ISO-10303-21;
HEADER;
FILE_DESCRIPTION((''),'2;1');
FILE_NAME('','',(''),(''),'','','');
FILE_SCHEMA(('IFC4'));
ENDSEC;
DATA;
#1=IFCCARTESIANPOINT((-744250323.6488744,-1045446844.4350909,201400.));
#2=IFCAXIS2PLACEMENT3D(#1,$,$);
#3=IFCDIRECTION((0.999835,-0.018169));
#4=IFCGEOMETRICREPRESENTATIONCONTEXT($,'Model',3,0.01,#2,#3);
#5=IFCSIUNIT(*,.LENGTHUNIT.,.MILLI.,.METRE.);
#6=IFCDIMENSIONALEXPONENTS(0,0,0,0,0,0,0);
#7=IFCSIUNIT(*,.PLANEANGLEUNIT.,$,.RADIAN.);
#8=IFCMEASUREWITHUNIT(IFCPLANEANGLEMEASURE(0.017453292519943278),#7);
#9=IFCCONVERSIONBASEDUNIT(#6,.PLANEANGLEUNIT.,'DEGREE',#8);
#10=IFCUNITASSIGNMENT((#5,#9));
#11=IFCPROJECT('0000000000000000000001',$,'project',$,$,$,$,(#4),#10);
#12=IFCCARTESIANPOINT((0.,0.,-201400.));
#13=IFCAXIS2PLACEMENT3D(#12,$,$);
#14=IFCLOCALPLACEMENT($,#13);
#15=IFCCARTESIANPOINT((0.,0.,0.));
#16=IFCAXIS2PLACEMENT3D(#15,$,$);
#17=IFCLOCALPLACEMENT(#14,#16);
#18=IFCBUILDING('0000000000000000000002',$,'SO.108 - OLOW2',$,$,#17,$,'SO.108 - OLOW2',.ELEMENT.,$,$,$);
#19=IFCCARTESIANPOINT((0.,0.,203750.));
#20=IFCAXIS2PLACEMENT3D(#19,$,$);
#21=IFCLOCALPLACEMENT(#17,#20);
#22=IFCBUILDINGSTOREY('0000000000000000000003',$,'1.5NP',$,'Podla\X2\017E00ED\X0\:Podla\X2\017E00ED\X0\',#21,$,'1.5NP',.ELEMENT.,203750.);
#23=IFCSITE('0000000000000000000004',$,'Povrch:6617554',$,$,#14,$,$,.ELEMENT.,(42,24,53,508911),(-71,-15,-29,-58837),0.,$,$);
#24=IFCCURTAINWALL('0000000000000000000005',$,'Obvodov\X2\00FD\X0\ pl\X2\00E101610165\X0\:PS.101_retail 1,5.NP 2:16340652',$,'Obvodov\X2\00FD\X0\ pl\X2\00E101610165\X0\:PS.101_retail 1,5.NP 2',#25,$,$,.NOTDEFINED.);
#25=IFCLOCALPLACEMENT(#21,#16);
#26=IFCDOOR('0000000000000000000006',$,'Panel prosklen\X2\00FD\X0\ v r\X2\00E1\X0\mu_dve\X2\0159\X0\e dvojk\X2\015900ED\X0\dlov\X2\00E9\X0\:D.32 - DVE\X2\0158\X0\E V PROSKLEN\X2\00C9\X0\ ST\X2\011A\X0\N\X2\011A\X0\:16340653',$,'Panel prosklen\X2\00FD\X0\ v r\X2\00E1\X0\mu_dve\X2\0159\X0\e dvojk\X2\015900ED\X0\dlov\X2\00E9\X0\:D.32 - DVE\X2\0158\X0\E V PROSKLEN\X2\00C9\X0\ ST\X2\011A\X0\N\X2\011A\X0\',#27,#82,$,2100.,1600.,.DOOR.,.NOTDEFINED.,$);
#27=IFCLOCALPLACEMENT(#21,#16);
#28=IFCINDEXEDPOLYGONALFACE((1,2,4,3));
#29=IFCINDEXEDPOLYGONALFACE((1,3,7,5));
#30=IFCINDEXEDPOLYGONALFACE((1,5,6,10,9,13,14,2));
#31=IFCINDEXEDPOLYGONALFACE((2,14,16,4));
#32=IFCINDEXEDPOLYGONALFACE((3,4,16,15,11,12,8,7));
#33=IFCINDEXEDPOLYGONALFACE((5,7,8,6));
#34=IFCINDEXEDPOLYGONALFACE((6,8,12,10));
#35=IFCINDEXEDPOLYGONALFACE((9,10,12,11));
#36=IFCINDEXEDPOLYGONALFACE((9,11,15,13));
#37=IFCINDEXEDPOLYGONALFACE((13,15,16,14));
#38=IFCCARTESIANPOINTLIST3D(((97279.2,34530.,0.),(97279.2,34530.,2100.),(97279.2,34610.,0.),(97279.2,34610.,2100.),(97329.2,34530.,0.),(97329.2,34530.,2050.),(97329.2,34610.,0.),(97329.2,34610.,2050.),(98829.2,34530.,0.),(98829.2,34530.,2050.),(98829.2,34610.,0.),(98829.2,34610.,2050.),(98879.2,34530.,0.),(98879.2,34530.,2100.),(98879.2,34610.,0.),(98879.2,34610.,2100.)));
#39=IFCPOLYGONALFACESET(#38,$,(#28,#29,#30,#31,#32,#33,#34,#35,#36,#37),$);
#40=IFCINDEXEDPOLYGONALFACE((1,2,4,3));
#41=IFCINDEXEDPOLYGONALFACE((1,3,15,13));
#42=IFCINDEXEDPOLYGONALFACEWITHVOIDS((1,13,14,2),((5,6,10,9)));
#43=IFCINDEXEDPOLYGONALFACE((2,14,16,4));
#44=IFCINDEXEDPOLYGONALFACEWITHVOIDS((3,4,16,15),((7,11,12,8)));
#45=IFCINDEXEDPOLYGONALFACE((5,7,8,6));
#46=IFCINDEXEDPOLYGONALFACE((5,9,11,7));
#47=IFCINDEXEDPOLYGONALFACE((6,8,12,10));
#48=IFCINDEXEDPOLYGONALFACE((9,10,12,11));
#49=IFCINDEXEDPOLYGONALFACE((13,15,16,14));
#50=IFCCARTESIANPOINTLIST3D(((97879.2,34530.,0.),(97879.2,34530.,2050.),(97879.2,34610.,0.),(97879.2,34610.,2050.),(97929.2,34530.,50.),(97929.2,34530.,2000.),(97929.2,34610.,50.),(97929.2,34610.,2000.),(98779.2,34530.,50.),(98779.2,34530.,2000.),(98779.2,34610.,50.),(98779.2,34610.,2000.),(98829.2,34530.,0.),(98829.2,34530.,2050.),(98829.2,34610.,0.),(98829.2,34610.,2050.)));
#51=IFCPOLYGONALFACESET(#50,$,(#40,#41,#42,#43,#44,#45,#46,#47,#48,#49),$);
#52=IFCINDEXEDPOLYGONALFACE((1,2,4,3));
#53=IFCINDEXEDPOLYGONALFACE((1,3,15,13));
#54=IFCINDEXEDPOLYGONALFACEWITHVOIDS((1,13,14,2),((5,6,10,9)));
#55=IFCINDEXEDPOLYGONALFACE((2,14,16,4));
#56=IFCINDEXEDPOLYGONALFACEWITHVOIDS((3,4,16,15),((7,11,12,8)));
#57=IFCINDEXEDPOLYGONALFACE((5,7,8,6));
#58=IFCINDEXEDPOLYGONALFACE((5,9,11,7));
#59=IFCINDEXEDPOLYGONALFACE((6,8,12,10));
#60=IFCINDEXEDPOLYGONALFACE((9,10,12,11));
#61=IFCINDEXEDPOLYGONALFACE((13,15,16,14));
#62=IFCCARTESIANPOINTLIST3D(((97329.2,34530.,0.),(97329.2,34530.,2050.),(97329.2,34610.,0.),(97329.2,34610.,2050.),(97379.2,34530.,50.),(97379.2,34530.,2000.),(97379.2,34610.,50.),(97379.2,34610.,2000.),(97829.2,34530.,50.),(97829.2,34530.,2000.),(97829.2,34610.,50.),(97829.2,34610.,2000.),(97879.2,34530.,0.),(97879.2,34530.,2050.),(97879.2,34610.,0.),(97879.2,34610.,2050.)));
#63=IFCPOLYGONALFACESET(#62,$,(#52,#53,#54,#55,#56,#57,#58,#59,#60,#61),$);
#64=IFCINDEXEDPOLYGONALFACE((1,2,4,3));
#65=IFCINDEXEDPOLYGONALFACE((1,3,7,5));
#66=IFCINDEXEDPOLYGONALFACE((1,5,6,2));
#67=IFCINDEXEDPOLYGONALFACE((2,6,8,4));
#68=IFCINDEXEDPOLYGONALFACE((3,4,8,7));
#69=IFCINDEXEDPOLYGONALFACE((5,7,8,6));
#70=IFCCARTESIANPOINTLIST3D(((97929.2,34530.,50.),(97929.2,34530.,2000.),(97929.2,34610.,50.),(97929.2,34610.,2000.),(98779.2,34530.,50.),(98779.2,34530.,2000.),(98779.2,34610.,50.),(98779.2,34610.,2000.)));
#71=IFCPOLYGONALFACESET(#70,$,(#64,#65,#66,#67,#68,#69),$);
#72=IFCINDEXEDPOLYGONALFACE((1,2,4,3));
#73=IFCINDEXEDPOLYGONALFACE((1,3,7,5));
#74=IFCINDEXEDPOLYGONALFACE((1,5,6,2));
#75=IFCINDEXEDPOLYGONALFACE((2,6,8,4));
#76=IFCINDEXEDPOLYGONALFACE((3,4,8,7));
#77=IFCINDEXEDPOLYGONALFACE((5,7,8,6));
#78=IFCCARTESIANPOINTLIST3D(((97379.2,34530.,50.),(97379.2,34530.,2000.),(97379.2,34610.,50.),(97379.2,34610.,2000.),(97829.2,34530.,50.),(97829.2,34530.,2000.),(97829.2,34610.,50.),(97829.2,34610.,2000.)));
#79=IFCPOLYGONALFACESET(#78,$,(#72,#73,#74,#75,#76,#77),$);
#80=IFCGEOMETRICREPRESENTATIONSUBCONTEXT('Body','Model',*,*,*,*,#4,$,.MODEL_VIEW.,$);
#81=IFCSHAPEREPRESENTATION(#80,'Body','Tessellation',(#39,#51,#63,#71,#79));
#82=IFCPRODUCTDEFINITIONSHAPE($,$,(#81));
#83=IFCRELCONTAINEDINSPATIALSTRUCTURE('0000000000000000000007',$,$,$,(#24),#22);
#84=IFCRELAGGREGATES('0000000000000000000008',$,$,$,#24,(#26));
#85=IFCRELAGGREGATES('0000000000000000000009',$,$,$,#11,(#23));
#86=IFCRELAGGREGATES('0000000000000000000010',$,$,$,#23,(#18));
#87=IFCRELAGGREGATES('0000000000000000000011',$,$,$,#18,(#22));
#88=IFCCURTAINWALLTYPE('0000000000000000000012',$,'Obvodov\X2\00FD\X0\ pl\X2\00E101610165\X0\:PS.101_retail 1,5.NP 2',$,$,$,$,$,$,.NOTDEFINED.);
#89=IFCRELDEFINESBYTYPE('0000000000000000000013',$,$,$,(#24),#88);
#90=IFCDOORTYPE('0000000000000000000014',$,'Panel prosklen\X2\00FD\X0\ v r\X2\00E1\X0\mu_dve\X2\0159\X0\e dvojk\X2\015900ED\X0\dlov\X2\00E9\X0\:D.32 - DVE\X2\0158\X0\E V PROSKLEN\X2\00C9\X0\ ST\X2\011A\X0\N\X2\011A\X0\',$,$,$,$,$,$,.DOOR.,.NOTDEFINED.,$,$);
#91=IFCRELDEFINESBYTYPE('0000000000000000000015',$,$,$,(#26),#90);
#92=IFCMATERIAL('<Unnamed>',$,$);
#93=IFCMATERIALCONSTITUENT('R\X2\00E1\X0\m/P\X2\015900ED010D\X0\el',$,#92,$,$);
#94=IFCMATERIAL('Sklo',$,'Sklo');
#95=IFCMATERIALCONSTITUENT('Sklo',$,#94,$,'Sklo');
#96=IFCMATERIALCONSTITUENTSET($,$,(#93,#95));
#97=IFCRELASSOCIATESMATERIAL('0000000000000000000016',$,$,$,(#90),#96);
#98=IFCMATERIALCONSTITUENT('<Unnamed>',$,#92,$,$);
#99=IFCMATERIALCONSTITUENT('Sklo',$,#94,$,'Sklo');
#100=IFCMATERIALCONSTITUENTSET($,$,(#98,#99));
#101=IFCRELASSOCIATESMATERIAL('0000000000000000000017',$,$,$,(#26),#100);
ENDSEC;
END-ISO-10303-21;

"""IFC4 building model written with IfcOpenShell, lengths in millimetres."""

from ifc_helpers import new_model, entity, si_unit, converted_unit, direction, frame, origin, place, context, subcontext, project, spatial, indexed_curve, outline, extrude, source, transform, mapped, material, constituent, constituent_set, type_object, type_shapes, element, aggregate, save


model = new_model("IFC4")

# Units and contexts
model_context = context("Model", 3, precision=0.01, world=frame((-744250323.6488744, -1045446844.4350909, 201400.0)), true_north=direction((0.999835, -0.018169)))
body_context = subcontext(model_context, "Body", "Model", "MODEL_VIEW")
ifc_project = project(units=[si_unit("LENGTHUNIT", "METRE", prefix="MILLI"), converted_unit("PLANEANGLEUNIT", "DEGREE", entity("IfcPlaneAngleMeasure", 0.017453292519943278), si_unit("PLANEANGLEUNIT", "RADIAN"), dimensions=[0, 0, 0, 0, 0, 0, 0])], contexts=[model_context])

# Site, building, storey
site_placement = place(None, frame((0.0, 0.0, -201400.0)))
site = spatial("IfcSite", under=ifc_project, at=site_placement, Name="Povrch:6617554", CompositionType="ELEMENT", RefLatitude=(42, 24, 53, 508911), RefLongitude=(-71, -15, -29, -58837), RefElevation=0.0)
building_placement = place(site_placement, origin())
building = spatial("IfcBuilding", under=site, at=building_placement, Name="SO.108 - OLOW2", LongName="SO.108 - OLOW2", CompositionType="ELEMENT")
storey_placement = place(building_placement, frame((0.0, 0.0, 203750.0)))
storey = spatial("IfcBuildingStorey", under=building, at=storey_placement, Name="1.5NP", ObjectType="Podlaží:Podlaží", LongName="1.5NP", CompositionType="ELEMENT", Elevation=203750.0)

# Shared definitions
ifc_material_1 = material(Name="<Unnamed>")

# Curtain wall
curtain_wall_type_1 = type_object("IfcCurtainWallType", Name="Obvodový plášť:PS.101_retail 1,5.NP 2", PredefinedType="NOTDEFINED")
curtain_wall_1_placement = place(storey_placement, frame((0.0, 0.0, -203750.0)))
curtain_wall_1 = element("IfcCurtainWall", 1, at=curtain_wall_1_placement, inside=storey, type_object=curtain_wall_type_1, Name="Obvodový plášť:PS.101_retail 1,5.NP 2:16340652", ObjectType="Obvodový plášť:PS.101_retail 1,5.NP 2", PredefinedType="NOTDEFINED")

# Shared definitions
ifc_material_2 = material(Name="Sklo", Category="Sklo")

# Door
ifc_constituent_1 = constituent(ifc_material_1, Name="<Unnamed>")
ifc_constituent_2 = constituent(ifc_material_2, Name="Sklo", Category="Sklo")
ifc_constituent_set_1 = constituent_set(constituents=[ifc_constituent_1, ifc_constituent_2])
ifc_constituent_3 = constituent(ifc_material_1, Name="Rám/Příčel")
ifc_constituent_4 = constituent(ifc_material_2, Name="Sklo", Category="Sklo")
ifc_constituent_set_2 = constituent_set(constituents=[ifc_constituent_3, ifc_constituent_4])
door_type = type_object("IfcDoorType", Name="Panel prosklený v rámu_dveře dvojkřídlové:D.32 - DVEŘE V PROSKLENÉ STĚNĚ", OperationType="NOTDEFINED", PredefinedType="DOOR", material=ifc_constituent_set_2)
shared_shape_1 = source(origin(), body_context, "Body", "SweptSolid", [
    extrude(outline(indexed_curve([(-800.0, -1062.5), (800.0, -1062.5), (800.0, 1037.5), (750.0, 1037.5), (750.0, -1012.5), (-750.0, -1012.5), (-750.0, 1037.5), (-800.0, 1037.5), (-800.0, -1062.5)], self_intersect=False)), frame((0.0, -80.0, 1037.5), z_axis=(0.0, 1.0, 0.0), x_axis=(1.0, 0.0, 0.0)), (0.0, 0.0, 1.0), 80.0),
    extrude(outline(indexed_curve([(-1025.0, -475.0), (1025.0, -475.0), (1025.0, 475.0), (-1025.0, 475.0), (-1025.0, -475.0)], self_intersect=False), holes=[indexed_curve([(-975.0, -425.0), (-975.0, 425.0), (975.0, 425.0), (975.0, -425.0), (-975.0, -425.0)], self_intersect=False)]), frame((275.0, -80.0, 1025.0), z_axis=(0.0, 1.0, 0.0), x_axis=(0.0, 0.0, -1.0)), (0.0, 0.0, 1.0), 80.0),
    extrude(outline(indexed_curve([(-1025.0, -275.0), (1025.0, -275.0), (1025.0, 275.0), (-1025.0, 275.0), (-1025.0, -275.0)], self_intersect=False), holes=[indexed_curve([(-975.0, -225.0), (-975.0, 225.0), (975.0, 225.0), (975.0, -225.0), (-975.0, -225.0)], self_intersect=False)]), frame((-475.0, -80.0, 1025.0), z_axis=(0.0, 1.0, 0.0), x_axis=(0.0, 0.0, -1.0)), (0.0, 0.0, 1.0), 80.0),
    extrude(outline(indexed_curve([(-40.0, -425.0), (40.0, -425.0), (40.0, 425.0), (-40.0, 425.0), (-40.0, -425.0)], self_intersect=False)), frame((275.0, -40.0, 50.0), z_axis=(0.0, 0.0, 1.0), x_axis=(0.0, 1.0, 0.0)), (0.0, 0.0, 1.0), 1950.0),
    extrude(outline(indexed_curve([(-40.0, -225.0), (40.0, -225.0), (40.0, 225.0), (-40.0, 225.0), (-40.0, -225.0)], self_intersect=False)), frame((-475.0, -40.0, 50.0), z_axis=(0.0, 0.0, 1.0), x_axis=(0.0, 1.0, 0.0)), (0.0, 0.0, 1.0), 1950.0),
])
type_shapes(door_type, [shared_shape_1])
door_placement = place(curtain_wall_1_placement, frame((98079.2, 34610.0, 203750.0)))
door = element("IfcDoor", 2, at=door_placement, type_object=door_type, material=ifc_constituent_set_1, Name="Panel prosklený v rámu_dveře dvojkřídlové:D.32 - DVEŘE V PROSKLENÉ STĚNĚ:16340653", ObjectType="Panel prosklený v rámu_dveře dvojkřídlové:D.32 - DVEŘE V PROSKLENÉ STĚNĚ", OperationType="NOTDEFINED", OverallHeight=2100.0, OverallWidth=1600.0, PredefinedType="DOOR", context=body_context, shape_type="MappedRepresentation", body=[
    mapped(shared_shape_1, transform((0.0, 0.0, 0.0), scale=1.0)),
])
aggregate(curtain_wall_1, [door])

save(model, "model.ifc")
